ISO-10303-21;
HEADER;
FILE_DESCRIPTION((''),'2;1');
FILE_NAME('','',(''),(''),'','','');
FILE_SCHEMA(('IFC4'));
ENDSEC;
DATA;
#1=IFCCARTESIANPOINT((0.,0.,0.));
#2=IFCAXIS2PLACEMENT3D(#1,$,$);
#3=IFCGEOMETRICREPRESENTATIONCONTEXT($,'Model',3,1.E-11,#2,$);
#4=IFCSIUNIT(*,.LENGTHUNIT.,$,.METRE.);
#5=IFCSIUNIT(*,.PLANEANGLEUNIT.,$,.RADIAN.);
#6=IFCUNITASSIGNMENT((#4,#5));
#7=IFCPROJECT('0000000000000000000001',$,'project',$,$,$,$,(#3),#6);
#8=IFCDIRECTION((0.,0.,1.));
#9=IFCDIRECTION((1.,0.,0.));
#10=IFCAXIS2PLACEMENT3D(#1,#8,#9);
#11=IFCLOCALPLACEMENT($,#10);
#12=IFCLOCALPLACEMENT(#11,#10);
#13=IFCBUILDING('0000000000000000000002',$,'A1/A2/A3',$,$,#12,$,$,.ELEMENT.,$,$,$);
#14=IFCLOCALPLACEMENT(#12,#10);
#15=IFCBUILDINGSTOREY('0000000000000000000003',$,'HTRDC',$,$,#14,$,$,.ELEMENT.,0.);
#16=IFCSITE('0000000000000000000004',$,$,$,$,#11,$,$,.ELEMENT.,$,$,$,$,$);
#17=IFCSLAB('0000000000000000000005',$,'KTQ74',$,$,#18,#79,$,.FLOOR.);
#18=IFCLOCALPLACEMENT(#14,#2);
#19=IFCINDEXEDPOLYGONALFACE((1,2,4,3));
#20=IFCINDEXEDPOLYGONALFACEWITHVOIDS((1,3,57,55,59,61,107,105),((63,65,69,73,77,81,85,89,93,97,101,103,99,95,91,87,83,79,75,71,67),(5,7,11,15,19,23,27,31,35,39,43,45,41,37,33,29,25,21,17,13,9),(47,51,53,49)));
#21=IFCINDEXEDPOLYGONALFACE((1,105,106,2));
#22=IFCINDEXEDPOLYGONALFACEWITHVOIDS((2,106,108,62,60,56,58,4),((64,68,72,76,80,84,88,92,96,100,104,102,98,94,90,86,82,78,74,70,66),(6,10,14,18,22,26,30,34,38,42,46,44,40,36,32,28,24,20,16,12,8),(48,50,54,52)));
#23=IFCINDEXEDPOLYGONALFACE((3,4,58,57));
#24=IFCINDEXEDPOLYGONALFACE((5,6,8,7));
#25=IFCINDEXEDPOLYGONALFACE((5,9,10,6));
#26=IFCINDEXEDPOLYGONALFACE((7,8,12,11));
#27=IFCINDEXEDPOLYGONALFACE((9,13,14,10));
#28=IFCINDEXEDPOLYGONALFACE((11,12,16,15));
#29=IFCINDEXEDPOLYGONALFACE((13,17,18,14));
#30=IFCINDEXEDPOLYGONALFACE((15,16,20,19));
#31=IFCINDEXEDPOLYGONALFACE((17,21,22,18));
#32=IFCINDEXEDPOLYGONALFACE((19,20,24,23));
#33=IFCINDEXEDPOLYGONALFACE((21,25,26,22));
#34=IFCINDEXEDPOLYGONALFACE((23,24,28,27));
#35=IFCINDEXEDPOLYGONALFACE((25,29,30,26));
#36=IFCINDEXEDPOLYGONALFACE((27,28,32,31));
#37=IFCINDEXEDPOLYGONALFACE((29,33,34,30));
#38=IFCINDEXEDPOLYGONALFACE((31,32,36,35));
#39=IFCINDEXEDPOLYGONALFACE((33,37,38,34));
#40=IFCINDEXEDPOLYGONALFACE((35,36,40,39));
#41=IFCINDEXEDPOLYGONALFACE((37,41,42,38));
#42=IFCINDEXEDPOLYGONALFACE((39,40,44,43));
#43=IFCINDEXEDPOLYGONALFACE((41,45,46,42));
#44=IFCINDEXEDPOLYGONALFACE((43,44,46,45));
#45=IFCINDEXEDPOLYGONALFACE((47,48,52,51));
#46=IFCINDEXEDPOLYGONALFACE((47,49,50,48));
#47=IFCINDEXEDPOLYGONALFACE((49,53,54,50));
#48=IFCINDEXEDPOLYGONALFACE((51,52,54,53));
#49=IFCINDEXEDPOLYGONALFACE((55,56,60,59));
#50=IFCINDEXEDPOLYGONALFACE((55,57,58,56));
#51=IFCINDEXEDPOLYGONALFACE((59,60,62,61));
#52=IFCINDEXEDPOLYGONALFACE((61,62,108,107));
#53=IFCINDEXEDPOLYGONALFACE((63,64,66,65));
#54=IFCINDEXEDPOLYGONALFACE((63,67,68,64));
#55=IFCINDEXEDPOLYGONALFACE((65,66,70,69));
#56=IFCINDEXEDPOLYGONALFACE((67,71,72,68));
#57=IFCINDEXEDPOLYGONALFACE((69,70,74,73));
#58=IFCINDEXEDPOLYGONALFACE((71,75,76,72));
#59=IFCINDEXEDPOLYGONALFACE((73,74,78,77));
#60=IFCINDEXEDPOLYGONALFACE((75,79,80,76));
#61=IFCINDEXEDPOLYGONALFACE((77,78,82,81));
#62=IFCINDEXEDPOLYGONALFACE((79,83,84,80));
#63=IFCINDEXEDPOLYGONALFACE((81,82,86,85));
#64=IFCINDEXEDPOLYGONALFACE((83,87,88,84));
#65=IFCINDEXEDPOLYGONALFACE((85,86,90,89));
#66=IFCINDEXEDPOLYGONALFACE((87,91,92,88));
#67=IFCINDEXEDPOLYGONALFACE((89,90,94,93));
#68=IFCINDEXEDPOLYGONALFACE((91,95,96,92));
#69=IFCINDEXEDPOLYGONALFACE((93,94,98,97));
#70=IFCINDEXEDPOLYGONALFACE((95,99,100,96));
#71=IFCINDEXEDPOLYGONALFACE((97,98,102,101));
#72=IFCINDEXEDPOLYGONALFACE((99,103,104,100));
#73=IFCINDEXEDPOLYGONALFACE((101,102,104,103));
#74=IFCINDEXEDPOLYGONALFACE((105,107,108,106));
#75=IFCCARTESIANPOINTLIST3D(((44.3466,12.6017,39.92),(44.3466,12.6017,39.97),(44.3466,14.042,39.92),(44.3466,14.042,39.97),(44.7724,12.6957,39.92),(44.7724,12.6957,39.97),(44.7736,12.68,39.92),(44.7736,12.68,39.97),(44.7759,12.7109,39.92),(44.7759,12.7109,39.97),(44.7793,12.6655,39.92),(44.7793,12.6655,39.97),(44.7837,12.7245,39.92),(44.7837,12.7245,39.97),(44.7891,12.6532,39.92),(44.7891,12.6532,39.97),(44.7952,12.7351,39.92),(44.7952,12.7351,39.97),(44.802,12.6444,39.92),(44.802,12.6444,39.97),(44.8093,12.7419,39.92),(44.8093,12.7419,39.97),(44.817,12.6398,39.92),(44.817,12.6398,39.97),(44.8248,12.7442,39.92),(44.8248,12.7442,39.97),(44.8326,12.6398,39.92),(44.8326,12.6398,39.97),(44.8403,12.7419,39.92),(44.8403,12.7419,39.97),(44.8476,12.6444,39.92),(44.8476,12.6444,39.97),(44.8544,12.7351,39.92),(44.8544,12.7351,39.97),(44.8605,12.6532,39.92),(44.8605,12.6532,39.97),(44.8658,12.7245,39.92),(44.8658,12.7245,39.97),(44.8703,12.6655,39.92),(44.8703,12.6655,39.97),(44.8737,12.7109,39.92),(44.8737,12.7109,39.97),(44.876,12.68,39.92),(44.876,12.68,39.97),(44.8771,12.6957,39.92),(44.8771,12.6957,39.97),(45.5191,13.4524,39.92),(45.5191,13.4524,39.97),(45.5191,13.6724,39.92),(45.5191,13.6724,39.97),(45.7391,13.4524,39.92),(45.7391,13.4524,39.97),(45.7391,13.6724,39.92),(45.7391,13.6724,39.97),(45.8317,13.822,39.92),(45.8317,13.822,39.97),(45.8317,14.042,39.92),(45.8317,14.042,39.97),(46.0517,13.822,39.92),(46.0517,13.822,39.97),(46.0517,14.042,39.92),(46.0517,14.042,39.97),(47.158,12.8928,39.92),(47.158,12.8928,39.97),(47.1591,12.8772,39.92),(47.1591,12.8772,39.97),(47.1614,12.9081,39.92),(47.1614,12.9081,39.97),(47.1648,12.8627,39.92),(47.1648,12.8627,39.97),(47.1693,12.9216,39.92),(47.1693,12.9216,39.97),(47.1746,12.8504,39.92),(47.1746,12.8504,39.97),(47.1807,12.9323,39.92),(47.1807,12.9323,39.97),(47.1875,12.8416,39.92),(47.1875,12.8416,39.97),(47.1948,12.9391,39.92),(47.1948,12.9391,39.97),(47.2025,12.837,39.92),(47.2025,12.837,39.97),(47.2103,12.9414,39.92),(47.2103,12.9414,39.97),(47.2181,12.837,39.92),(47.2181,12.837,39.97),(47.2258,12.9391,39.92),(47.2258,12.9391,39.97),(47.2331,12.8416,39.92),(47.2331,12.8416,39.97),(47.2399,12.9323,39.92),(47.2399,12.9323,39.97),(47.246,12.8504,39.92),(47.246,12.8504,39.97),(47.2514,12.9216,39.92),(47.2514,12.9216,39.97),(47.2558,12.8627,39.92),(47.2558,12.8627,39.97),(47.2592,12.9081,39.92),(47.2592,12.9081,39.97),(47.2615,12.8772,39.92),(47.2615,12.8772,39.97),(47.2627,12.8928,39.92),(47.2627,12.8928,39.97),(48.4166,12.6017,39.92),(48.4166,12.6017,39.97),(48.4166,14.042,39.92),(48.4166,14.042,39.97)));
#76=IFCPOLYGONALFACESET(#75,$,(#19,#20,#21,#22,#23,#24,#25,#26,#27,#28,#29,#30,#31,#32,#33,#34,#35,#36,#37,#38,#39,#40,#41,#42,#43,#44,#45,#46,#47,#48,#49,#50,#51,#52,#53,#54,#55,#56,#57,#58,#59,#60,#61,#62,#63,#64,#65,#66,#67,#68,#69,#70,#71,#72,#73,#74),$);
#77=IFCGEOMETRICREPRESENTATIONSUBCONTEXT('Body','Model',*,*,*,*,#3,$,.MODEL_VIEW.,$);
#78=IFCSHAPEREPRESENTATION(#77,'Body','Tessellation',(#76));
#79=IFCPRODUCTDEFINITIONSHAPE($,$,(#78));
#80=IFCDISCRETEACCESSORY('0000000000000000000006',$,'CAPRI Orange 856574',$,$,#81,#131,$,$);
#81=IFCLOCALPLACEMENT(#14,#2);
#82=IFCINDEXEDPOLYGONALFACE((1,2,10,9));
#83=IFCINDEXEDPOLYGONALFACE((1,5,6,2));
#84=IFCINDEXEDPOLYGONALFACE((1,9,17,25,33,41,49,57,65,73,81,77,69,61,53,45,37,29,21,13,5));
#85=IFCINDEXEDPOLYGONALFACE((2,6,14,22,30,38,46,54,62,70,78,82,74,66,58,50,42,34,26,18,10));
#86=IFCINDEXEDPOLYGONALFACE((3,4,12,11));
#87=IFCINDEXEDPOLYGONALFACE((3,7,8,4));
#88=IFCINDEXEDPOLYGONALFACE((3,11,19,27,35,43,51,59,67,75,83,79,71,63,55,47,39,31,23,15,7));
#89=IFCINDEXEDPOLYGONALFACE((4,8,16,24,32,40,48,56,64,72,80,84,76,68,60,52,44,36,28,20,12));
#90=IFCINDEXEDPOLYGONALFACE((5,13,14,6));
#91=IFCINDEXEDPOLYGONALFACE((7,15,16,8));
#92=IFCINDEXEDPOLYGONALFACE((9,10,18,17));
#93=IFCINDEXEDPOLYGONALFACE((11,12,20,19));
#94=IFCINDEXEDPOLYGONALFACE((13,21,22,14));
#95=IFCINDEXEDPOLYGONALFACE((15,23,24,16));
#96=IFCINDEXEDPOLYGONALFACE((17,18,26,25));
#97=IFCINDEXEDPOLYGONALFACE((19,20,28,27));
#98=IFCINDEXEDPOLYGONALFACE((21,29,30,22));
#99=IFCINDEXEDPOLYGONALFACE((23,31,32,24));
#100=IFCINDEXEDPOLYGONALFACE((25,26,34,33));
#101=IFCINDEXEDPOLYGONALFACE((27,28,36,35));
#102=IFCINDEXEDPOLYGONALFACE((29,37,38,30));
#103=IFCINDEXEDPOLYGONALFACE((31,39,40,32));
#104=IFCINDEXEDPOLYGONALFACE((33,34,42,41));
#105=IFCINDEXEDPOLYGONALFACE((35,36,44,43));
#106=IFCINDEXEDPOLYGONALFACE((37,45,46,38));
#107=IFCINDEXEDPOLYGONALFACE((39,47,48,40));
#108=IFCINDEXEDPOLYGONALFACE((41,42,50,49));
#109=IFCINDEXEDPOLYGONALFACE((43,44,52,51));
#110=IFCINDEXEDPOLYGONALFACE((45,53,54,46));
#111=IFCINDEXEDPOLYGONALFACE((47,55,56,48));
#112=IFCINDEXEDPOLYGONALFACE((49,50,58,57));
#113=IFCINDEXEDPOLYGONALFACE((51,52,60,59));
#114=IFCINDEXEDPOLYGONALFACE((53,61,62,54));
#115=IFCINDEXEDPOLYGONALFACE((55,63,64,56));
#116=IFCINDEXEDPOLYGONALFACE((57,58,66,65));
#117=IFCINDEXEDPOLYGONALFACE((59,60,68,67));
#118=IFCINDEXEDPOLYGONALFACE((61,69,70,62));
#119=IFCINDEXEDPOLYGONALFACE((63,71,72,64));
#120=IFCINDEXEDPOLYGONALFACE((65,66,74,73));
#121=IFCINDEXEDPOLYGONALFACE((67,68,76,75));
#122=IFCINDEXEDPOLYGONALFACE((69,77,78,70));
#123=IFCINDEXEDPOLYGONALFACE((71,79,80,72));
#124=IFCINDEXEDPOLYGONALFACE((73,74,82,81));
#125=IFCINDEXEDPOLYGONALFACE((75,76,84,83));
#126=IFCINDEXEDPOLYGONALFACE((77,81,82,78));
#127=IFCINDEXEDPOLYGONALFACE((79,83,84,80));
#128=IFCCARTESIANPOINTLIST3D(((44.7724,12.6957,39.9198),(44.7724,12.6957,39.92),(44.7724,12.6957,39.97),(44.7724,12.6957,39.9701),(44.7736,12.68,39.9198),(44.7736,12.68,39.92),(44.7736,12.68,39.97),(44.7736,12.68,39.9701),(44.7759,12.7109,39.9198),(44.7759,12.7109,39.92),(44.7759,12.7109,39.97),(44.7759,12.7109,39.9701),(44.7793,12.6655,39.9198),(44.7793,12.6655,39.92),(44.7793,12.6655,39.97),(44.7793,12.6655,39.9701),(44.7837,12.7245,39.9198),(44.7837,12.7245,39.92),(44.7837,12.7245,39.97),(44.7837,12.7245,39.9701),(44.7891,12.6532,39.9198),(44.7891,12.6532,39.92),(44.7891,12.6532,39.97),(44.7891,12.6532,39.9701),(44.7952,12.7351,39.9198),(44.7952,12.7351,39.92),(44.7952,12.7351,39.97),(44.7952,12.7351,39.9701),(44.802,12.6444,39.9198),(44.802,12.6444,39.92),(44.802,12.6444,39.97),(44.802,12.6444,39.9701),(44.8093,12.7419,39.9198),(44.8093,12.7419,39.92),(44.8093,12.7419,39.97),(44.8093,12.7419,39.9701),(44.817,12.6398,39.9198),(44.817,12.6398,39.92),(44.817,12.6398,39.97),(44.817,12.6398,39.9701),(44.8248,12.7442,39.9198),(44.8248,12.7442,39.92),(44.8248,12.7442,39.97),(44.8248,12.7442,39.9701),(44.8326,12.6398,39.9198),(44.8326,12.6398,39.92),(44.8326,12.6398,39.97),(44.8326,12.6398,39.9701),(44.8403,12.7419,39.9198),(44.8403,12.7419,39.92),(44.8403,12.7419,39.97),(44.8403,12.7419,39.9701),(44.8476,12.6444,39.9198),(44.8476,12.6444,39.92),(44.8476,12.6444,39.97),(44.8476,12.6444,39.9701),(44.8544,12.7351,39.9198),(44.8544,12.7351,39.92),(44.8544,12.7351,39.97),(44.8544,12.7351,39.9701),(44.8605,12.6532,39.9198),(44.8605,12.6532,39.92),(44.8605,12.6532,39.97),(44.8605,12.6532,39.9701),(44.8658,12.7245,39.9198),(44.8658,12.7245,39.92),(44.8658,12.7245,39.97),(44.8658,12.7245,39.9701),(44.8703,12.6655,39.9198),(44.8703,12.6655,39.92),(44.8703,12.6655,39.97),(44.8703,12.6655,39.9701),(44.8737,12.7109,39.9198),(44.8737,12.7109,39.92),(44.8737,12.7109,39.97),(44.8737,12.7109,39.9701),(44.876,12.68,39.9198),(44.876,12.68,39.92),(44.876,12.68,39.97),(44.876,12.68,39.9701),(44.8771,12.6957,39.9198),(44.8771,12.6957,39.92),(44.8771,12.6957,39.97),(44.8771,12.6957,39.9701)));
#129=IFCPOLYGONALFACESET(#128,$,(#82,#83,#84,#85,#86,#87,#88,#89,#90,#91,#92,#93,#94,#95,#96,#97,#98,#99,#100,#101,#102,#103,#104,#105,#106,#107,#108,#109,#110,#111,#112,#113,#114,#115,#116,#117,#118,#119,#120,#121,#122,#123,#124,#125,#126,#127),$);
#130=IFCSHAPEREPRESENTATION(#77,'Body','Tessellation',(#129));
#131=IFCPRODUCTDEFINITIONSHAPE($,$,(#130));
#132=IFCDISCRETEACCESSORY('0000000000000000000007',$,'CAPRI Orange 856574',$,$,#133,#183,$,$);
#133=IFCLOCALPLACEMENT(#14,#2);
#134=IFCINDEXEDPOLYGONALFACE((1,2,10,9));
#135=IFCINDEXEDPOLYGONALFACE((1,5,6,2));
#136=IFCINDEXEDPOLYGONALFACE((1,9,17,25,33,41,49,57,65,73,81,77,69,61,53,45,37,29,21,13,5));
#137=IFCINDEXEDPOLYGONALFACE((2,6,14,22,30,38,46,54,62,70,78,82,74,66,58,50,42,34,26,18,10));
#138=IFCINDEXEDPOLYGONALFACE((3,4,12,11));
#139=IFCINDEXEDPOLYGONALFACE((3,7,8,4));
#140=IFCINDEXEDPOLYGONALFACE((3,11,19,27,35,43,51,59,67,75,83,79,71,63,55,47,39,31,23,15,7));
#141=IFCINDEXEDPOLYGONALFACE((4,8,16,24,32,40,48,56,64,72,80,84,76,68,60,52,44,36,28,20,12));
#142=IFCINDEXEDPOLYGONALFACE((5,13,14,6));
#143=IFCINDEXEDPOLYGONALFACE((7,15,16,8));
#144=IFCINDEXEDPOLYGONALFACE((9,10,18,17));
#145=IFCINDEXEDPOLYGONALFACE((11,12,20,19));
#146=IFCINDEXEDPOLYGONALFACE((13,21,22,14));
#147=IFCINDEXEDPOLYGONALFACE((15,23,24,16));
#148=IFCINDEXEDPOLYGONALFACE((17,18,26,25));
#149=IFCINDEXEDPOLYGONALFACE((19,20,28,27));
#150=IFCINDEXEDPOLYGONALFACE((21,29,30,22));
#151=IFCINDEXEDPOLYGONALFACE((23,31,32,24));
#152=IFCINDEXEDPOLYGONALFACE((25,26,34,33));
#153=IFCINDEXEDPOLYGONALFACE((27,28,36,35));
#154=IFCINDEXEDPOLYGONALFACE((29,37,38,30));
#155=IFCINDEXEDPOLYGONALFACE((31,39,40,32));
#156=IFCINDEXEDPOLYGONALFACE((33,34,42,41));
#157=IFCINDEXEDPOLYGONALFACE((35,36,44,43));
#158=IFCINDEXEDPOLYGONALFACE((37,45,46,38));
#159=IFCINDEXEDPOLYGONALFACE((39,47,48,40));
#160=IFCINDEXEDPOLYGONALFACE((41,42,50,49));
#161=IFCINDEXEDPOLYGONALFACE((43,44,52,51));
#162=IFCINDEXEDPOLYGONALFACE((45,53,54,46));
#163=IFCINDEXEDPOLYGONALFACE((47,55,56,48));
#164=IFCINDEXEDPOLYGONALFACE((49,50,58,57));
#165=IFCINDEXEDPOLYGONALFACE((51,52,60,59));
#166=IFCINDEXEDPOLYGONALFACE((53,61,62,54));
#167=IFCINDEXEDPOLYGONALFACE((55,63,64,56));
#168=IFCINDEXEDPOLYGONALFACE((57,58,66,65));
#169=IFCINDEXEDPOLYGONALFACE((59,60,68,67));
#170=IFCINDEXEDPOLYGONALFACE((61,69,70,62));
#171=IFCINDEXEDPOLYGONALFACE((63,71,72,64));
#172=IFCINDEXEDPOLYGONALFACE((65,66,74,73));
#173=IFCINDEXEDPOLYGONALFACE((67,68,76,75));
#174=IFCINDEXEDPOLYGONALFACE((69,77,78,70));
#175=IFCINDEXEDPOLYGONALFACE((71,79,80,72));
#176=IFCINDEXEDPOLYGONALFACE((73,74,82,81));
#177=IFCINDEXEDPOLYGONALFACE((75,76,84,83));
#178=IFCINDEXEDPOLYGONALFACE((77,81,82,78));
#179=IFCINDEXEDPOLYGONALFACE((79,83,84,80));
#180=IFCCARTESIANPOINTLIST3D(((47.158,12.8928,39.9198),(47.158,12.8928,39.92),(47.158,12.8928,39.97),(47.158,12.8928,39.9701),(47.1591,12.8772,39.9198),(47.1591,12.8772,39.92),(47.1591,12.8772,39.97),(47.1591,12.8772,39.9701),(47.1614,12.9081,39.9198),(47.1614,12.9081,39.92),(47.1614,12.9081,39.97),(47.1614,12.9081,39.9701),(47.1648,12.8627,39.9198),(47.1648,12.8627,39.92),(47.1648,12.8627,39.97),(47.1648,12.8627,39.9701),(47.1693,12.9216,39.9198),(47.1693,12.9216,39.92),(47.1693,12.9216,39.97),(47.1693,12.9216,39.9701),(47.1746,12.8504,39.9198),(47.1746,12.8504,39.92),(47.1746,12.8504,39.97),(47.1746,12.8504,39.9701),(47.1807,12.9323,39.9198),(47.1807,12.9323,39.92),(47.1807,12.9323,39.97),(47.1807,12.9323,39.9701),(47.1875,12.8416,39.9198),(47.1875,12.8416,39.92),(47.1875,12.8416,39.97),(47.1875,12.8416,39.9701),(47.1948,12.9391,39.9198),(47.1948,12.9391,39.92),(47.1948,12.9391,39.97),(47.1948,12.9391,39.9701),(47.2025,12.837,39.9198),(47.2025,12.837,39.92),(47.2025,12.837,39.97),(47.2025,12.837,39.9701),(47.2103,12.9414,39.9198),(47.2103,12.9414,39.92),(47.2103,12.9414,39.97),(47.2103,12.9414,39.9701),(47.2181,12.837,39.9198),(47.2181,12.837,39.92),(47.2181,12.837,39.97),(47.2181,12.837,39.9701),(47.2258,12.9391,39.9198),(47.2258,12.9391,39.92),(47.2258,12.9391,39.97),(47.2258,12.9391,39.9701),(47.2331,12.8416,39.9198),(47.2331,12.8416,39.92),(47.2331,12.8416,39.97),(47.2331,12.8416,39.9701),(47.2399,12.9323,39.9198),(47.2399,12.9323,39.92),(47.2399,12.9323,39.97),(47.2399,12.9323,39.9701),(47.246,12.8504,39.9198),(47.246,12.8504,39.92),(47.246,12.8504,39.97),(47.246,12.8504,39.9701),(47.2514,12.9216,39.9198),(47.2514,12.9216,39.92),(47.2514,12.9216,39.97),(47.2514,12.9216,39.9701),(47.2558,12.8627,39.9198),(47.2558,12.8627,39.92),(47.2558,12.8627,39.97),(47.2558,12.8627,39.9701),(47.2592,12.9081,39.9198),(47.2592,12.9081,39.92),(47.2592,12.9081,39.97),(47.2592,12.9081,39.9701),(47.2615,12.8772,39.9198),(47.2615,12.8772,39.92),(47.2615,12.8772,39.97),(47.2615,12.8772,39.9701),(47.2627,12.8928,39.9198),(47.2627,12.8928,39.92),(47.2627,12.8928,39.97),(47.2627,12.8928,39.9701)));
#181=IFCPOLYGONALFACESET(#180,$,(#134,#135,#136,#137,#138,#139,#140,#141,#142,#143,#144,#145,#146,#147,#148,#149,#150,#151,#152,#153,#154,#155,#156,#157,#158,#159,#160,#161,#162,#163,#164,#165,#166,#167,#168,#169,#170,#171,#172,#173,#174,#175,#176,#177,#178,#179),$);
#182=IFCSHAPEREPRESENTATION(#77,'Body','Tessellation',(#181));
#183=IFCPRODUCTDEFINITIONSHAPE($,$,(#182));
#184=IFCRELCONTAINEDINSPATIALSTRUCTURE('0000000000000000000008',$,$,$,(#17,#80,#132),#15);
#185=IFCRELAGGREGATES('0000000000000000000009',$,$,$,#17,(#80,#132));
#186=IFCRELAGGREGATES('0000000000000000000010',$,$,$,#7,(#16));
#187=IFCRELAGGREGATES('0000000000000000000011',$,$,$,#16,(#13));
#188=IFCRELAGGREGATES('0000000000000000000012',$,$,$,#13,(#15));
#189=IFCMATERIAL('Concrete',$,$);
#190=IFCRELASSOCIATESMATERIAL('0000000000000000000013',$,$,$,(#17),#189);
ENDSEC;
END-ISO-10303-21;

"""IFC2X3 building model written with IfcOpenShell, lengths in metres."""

from ifc_helpers import new_model, si_unit, frame, frame_2d, origin, origin_with_axes, origin_2d_with_axis, place, context, subcontext, project, spatial, polyline, circle, outline, extrude, material, element, aggregate, save


model = new_model("IFC2X3")

# Units and contexts
model_context = context("Model", 3, precision=1e-11, world=origin())
body_context = subcontext(model_context, "Body", "Model", "MODEL_VIEW")
ifc_project = project(units=[si_unit("LENGTHUNIT", "METRE"), si_unit("PLANEANGLEUNIT", "RADIAN")], contexts=[model_context])

# Site, building, storey
site_placement = place(None, origin_with_axes())
site = spatial("IfcSite", under=ifc_project, at=site_placement, CompositionType="ELEMENT")
building_placement = place(site_placement, origin_with_axes())
building = spatial("IfcBuilding", under=site, at=building_placement, Name="A1/A2/A3", CompositionType="ELEMENT")
storey_placement = place(building_placement, origin_with_axes())
storey = spatial("IfcBuildingStorey", under=building, at=storey_placement, Name="HTRDC", CompositionType="ELEMENT", Elevation=0.0)

# Shared definitions
ifc_material = material(Name="Concrete")

# Slab, openings
slab_1_placement = place(storey_placement, frame((44.3466, 12.6017, 39.92), z_axis=(0.0, 0.0, 1.0), x_axis=(1.0, 0.0, 0.0)))
slab_1 = element("IfcSlab", 1, at=slab_1_placement, inside=storey, material=ifc_material, Name="KTQ74", PredefinedType="FLOOR", context=body_context, shape_type="SweptSolid", body=[
    extrude(outline(polyline([(0.0, 0.0), (0.0, -4.07), (1.4403, -4.07), (1.4403, 0.0), (0.0, 0.0)])), frame((0.0, 0.0, 0.0), z_axis=(0.0, 0.0, 1.0), x_axis=(0.0, 1.0, 0.0)), (0.0, 0.0, 1.0), 0.05),
])
opening_1_placement = place(slab_1_placement, origin_with_axes())
element("IfcOpeningElement", 2, at=opening_1_placement, cuts=slab_1, ObjectType="Opening", context=body_context, shape_type="SweptSolid", body=[
    extrude(outline(polyline([(1.2203, -1.4852), (1.2203, -1.7052), (1.4403, -1.7052), (1.4403, -1.4852), (1.2203, -1.4852)])), frame((0.0, 0.0, 0.0), z_axis=(0.0, 0.0, 1.0), x_axis=(0.0, 1.0, 0.0)), (0.0, 0.0, 1.0), 0.05),
])
opening_2_placement = place(slab_1_placement, origin_with_axes())
element("IfcOpeningElement", 3, at=opening_2_placement, cuts=slab_1, ObjectType="Opening", context=body_context, shape_type="SweptSolid", body=[
    extrude(outline(polyline([(0.8507, -1.1726), (0.8507, -1.3926), (1.0707, -1.3926), (1.0707, -1.1726), (0.8507, -1.1726)])), frame((0.0, 0.0, 0.0), z_axis=(0.0, 0.0, 1.0), x_axis=(0.0, 1.0, 0.0)), (0.0, 0.0, 1.0), 0.05),
])
opening_3_placement = place(slab_1_placement, frame((0.4782, 0.09, 0.0), z_axis=(0.0, 0.0, 1.0), x_axis=(1.0, 0.0, 0.0)))
element("IfcOpeningElement", 4, at=opening_3_placement, cuts=slab_1, ObjectType="Opening", context=body_context, shape_type="SweptSolid", body=[
    extrude(circle(Radius=0.0525, at=origin_2d_with_axis()), frame((0.0, 0.0, 0.0), z_axis=(0.0, 0.0, 1.0), x_axis=(0.0, 1.0, 0.0)), (0.0, 0.0, 1.0), 0.05),
])
opening_4_placement = place(slab_1_placement, frame((2.8638, 0.2872, 0.0), z_axis=(0.0, 0.0, 1.0), x_axis=(1.0, 0.0, 0.0)))
element("IfcOpeningElement", 5, at=opening_4_placement, cuts=slab_1, ObjectType="Opening", context=body_context, shape_type="SweptSolid", body=[
    extrude(circle(Radius=0.0525, at=origin_2d_with_axis()), frame((0.0, 0.0, 0.0), z_axis=(0.0, 0.0, 1.0), x_axis=(0.0, 1.0, 0.0)), (0.0, 0.0, 1.0), 0.05),
])

# Discrete accessories
discrete_accessory_1_placement = place(storey_placement, frame((44.3466, 12.6017, 39.9198), z_axis=(0.0, 0.0, 1.0), x_axis=(1.0, 0.0, 0.0)))
discrete_accessory_1 = element("IfcDiscreteAccessory", 6, at=discrete_accessory_1_placement, inside=storey, Name="CAPRI Orange 856574", context=body_context, shape_type="SweptSolid", body=[
    extrude(circle(Radius=0.0525, at=frame_2d((0.09, -0.4782), x_axis=(1.0, 0.0))), frame((0.0, 0.0, 0.0), z_axis=(0.0, 0.0, 1.0), x_axis=(0.0, 1.0, 0.0)), (0.0, 0.0, 1.0), 0.0503),
])
discrete_accessory_2_placement = place(storey_placement, frame((44.3466, 12.6017, 39.9198), z_axis=(0.0, 0.0, 1.0), x_axis=(1.0, 0.0, 0.0)))
discrete_accessory_2 = element("IfcDiscreteAccessory", 7, at=discrete_accessory_2_placement, inside=storey, Name="CAPRI Orange 856574", context=body_context, shape_type="SweptSolid", body=[
    extrude(circle(Radius=0.0525, at=frame_2d((0.2872, -2.8638), x_axis=(1.0, 0.0))), frame((0.0, 0.0, 0.0), z_axis=(0.0, 0.0, 1.0), x_axis=(0.0, 1.0, 0.0)), (0.0, 0.0, 1.0), 0.0503),
])
aggregate(slab_1, [discrete_accessory_1, discrete_accessory_2])

save(model, "model.ifc")
